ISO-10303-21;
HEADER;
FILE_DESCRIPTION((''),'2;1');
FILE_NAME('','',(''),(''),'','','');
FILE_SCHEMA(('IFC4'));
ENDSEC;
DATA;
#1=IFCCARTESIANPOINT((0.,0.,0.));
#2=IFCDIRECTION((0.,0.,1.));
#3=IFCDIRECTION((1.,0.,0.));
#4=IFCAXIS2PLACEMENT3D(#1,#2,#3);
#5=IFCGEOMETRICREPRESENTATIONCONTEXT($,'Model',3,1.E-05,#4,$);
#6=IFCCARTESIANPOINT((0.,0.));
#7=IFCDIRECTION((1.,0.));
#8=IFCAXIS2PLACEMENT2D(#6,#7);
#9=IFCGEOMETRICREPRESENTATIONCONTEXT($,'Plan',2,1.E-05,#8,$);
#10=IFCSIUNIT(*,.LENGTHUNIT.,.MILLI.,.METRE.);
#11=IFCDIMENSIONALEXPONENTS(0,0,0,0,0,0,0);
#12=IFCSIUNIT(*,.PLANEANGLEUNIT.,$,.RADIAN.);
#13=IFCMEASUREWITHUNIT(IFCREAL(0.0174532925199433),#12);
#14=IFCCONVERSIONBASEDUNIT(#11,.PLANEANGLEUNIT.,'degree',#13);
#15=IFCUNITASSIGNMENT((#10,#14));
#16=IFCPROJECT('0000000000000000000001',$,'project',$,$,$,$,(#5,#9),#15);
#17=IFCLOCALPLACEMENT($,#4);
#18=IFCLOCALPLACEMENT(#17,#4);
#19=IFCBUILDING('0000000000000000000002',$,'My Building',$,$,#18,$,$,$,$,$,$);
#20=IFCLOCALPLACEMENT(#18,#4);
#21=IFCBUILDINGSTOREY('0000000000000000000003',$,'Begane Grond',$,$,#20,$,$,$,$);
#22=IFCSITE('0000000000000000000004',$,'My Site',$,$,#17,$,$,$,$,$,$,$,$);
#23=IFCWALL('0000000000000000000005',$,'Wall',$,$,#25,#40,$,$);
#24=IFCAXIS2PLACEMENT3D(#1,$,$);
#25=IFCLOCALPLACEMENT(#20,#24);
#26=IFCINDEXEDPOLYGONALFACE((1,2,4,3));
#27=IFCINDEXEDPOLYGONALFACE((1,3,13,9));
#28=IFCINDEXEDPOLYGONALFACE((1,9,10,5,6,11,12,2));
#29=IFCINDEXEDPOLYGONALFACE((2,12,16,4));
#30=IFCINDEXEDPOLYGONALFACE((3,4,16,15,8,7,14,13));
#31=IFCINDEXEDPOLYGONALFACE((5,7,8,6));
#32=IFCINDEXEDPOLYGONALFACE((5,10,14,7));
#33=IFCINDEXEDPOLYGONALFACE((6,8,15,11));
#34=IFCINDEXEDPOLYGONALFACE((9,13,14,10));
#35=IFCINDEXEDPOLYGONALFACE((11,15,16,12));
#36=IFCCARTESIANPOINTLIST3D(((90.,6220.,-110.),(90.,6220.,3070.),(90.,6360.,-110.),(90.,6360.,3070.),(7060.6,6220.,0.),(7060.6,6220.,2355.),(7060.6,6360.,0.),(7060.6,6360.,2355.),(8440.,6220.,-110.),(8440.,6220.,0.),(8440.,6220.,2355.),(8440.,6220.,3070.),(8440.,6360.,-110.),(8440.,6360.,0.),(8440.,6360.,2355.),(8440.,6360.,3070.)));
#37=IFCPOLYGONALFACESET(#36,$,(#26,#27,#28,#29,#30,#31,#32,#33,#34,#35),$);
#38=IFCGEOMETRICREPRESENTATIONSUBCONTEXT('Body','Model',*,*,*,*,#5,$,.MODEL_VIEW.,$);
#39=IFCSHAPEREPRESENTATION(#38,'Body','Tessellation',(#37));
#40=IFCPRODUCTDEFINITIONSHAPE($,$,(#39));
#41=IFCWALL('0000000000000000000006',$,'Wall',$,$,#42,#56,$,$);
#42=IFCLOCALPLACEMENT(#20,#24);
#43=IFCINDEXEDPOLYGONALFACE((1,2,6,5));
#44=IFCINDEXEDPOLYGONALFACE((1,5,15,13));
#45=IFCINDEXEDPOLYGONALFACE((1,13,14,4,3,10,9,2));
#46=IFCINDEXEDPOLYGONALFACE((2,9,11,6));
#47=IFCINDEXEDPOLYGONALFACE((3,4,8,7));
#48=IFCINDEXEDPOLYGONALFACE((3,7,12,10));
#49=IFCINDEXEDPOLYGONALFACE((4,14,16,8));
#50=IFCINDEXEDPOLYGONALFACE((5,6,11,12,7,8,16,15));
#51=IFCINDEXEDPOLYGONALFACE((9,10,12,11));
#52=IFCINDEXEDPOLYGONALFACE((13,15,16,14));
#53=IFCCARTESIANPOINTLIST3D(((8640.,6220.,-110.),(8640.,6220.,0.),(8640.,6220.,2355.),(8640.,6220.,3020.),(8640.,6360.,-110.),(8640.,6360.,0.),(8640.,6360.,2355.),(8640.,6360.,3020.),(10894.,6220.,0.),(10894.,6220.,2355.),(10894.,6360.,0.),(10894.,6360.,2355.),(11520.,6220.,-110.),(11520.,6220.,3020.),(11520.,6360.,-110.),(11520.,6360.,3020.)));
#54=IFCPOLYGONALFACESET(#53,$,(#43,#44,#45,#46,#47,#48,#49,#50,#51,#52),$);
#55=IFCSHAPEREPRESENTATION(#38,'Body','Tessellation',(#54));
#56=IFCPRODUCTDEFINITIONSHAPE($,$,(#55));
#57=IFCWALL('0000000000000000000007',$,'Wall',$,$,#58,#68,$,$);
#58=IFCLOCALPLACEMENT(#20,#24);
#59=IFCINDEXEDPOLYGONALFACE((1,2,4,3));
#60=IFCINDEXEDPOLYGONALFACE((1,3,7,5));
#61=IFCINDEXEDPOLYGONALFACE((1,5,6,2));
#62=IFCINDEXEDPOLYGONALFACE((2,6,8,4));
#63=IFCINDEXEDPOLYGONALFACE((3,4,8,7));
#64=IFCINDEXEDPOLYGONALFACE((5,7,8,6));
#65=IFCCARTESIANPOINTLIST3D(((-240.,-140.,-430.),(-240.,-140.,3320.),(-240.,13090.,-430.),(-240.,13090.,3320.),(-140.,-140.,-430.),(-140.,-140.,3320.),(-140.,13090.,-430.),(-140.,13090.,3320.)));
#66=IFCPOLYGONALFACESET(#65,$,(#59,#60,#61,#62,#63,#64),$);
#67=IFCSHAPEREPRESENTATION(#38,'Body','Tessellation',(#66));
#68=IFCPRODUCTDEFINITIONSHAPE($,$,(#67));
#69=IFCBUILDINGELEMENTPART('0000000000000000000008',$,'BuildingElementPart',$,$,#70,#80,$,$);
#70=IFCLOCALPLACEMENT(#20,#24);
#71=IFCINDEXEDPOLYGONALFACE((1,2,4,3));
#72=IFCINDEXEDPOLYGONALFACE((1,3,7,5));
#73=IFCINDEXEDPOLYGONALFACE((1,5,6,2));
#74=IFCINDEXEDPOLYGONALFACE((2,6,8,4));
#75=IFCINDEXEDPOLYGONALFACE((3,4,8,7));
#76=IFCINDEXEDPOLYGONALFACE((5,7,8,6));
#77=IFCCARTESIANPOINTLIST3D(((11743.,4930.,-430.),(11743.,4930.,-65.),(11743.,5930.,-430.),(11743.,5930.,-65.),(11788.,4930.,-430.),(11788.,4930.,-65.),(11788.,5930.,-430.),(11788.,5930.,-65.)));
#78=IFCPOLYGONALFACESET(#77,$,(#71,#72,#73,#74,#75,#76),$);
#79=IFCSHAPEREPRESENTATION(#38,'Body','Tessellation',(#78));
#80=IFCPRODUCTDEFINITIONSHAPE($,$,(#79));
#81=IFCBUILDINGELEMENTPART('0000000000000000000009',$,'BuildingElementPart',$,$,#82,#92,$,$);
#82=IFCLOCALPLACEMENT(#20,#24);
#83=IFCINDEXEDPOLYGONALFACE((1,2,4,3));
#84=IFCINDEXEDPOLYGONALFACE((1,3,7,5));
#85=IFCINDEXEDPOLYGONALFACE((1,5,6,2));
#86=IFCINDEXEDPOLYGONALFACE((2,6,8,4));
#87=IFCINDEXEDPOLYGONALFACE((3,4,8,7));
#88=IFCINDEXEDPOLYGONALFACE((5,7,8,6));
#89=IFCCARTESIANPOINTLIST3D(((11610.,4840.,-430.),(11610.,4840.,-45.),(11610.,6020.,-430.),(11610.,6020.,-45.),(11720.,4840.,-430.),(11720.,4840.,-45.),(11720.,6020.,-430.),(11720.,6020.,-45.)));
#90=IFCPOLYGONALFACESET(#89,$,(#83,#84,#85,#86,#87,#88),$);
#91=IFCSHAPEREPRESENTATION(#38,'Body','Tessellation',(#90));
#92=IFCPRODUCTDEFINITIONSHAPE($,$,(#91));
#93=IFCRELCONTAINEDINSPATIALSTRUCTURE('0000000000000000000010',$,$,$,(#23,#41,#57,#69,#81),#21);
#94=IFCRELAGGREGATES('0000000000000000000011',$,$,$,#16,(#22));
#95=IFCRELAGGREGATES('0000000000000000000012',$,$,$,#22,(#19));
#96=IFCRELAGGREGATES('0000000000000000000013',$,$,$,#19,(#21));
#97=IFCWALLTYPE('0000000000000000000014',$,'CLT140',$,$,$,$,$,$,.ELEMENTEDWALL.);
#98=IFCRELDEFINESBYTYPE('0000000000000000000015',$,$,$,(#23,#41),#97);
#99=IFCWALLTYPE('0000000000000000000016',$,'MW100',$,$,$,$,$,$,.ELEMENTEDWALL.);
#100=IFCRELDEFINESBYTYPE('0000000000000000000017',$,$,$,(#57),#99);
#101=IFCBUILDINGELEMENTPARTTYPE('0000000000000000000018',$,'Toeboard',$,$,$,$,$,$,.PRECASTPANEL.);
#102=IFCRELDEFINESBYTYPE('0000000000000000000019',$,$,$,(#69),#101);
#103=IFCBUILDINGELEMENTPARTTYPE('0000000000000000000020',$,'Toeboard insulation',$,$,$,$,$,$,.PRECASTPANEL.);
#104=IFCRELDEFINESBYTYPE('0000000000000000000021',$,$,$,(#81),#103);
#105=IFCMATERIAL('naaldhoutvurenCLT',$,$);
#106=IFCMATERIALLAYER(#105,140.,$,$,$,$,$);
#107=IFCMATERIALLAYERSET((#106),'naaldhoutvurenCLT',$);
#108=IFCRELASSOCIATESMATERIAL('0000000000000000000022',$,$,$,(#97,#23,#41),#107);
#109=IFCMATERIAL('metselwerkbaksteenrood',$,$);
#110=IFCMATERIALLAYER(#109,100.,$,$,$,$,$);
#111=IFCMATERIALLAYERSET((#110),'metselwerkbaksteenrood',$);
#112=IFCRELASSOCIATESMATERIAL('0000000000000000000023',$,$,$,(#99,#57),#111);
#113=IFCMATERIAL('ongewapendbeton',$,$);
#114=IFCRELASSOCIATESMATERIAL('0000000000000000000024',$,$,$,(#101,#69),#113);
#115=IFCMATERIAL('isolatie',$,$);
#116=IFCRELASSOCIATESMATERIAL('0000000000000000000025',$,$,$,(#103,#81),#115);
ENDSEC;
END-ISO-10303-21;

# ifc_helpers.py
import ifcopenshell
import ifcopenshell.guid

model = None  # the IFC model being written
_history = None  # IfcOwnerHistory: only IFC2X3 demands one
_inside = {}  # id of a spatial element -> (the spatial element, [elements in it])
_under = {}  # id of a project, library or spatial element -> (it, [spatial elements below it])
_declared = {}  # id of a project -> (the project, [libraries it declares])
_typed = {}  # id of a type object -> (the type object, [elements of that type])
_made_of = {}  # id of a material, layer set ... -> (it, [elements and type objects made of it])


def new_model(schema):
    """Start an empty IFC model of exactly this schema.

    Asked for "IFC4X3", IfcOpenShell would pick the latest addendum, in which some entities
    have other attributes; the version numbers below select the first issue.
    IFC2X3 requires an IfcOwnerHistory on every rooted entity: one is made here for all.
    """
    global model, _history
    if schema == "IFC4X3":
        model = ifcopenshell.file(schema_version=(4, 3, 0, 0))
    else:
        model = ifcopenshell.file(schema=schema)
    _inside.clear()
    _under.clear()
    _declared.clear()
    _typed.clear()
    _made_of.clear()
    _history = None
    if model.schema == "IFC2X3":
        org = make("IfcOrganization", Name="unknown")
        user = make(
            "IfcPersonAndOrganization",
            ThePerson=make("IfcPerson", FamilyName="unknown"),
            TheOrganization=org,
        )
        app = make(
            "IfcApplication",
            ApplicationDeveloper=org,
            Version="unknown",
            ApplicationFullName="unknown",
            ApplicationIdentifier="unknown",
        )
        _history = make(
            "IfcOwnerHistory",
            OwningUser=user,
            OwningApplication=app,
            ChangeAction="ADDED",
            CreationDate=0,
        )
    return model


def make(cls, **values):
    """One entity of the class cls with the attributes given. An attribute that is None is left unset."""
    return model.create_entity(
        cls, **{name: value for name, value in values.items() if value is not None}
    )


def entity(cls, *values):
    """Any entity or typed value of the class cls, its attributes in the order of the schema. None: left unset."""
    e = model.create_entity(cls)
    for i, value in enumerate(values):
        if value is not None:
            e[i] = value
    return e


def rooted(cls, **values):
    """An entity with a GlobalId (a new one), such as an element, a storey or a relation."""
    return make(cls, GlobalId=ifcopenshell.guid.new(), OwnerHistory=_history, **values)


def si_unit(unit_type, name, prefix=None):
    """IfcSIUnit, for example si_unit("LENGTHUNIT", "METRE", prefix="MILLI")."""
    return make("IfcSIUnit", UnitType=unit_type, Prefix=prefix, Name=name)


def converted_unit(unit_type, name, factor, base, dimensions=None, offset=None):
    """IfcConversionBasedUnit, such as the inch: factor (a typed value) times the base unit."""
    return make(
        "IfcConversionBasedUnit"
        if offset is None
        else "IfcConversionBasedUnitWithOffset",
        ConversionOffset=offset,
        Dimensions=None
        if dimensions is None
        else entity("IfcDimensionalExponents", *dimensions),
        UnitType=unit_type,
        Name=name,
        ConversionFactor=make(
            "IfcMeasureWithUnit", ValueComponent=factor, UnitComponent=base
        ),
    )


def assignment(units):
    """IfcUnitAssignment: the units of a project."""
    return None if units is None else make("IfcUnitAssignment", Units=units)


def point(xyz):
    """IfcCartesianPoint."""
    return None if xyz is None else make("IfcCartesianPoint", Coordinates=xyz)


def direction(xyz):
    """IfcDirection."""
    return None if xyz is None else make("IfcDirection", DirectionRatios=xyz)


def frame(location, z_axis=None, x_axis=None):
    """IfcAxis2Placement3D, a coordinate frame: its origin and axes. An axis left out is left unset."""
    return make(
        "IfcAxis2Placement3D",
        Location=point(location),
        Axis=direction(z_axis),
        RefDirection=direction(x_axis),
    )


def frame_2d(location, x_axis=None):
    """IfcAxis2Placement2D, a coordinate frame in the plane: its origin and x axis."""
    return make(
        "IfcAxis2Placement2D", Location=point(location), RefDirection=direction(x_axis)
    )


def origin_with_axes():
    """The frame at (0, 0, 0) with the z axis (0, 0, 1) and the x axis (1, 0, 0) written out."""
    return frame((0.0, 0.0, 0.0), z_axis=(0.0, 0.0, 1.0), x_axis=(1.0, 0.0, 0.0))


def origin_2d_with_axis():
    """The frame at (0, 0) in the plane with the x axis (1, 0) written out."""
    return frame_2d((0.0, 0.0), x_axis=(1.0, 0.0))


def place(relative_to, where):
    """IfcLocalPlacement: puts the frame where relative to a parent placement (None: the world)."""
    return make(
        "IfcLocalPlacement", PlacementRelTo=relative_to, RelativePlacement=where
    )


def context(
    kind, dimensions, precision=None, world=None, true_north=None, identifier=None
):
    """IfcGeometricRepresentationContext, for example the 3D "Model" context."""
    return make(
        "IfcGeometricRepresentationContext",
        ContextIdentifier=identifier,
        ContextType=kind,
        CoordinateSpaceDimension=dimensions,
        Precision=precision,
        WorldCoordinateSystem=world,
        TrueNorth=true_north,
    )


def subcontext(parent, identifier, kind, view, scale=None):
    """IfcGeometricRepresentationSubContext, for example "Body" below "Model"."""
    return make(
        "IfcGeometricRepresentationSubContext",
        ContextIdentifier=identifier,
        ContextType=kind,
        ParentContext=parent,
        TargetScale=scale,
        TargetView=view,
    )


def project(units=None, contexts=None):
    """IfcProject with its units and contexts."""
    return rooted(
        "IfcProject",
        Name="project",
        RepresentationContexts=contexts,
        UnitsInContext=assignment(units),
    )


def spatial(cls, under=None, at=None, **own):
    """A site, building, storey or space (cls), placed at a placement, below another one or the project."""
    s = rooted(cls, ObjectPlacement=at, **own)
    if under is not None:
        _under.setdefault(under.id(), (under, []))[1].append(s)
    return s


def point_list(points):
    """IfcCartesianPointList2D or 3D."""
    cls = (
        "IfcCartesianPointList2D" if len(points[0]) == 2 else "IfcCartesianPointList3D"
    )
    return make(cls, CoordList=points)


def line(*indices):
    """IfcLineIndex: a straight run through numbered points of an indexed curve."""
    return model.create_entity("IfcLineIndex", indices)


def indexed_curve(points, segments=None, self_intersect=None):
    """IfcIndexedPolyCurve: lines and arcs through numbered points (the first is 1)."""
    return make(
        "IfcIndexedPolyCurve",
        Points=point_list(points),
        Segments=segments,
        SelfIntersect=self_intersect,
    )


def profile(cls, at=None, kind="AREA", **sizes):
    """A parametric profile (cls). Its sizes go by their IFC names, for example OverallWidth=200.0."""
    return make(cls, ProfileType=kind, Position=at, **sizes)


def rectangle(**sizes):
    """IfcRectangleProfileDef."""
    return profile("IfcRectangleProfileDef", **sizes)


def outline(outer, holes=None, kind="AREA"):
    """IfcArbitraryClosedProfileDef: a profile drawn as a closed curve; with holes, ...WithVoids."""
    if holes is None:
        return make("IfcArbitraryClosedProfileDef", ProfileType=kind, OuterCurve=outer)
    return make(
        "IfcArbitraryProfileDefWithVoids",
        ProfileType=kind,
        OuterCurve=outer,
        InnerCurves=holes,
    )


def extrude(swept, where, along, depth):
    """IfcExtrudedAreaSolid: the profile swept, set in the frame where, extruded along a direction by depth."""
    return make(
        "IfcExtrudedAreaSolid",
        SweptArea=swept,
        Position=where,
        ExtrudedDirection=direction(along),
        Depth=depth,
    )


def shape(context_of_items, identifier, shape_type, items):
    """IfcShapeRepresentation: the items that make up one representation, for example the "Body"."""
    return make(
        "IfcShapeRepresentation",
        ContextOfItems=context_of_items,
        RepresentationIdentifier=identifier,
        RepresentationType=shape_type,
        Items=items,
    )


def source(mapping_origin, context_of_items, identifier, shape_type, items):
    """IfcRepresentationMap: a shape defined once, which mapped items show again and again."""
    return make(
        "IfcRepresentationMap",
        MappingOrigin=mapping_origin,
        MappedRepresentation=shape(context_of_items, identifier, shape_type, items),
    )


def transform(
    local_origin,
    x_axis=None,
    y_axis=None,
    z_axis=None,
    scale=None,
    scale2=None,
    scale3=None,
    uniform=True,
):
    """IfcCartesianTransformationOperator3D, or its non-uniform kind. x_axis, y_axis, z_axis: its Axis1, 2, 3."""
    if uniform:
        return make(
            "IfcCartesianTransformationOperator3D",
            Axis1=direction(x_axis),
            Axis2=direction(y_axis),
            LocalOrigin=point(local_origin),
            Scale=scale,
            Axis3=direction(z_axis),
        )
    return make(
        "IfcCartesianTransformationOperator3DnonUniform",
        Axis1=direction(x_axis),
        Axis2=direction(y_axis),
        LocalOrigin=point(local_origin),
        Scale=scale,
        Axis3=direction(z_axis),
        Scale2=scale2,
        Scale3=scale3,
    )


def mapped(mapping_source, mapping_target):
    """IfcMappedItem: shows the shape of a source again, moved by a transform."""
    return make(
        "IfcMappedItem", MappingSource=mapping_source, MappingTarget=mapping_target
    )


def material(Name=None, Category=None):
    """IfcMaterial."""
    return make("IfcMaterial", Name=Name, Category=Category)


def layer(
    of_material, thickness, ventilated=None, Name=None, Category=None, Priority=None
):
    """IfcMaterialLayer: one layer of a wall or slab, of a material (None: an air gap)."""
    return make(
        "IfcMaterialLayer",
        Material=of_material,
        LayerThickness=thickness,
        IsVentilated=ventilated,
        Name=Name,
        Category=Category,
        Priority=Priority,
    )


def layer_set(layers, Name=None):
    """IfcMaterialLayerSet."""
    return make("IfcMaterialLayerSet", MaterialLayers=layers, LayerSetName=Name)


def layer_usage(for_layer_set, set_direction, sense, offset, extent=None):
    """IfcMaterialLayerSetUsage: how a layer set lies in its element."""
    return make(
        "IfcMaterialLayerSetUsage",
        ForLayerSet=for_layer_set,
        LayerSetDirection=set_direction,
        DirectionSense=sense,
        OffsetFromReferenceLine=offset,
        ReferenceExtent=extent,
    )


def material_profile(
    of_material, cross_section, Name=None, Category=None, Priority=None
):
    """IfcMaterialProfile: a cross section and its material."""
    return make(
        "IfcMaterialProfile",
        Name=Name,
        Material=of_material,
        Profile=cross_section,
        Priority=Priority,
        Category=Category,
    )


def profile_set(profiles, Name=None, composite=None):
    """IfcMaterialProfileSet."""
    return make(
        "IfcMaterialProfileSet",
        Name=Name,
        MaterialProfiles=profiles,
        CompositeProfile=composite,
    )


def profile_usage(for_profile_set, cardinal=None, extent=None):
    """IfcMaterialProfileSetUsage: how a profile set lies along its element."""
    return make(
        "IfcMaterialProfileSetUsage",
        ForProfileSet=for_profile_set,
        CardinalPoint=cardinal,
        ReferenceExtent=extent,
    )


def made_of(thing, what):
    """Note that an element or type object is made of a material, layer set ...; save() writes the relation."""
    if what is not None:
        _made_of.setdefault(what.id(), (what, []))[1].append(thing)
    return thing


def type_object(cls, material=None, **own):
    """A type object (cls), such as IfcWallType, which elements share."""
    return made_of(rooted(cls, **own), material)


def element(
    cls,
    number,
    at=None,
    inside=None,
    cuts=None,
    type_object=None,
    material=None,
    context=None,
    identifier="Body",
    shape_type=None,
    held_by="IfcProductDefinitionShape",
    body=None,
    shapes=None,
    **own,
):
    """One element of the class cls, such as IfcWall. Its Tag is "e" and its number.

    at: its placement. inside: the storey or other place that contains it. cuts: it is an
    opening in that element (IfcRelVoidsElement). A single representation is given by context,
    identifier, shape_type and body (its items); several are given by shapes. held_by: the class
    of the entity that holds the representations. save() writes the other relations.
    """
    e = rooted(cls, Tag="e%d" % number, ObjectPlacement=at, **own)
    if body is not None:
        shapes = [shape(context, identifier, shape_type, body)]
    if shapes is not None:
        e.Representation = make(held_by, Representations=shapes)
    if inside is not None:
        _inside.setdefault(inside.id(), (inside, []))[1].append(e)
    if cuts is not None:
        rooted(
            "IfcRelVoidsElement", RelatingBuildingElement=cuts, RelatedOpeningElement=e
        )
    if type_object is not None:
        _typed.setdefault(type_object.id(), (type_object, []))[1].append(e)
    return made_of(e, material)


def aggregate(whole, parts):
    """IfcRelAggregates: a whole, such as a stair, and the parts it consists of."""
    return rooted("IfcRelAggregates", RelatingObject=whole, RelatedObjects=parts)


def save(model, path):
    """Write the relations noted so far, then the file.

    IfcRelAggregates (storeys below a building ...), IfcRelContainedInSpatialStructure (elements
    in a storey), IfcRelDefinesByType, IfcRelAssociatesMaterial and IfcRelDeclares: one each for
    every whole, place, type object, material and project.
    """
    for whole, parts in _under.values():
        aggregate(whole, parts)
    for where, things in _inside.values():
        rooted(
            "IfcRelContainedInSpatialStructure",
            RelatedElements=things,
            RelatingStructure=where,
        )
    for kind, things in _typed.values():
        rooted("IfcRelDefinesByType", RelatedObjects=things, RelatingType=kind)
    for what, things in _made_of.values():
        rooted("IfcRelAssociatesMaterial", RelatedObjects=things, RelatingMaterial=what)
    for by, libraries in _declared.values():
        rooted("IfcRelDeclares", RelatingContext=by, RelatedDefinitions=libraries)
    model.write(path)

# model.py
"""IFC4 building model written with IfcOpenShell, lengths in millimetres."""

from ifc_helpers import new_model, entity, si_unit, converted_unit, frame, origin_with_axes, origin_2d_with_axis, place, context, subcontext, project, spatial, line, indexed_curve, rectangle, outline, extrude, source, transform, mapped, material, layer, layer_set, layer_usage, material_profile, profile_set, profile_usage, type_object, element, save


model = new_model("IFC4")

# Units and contexts
model_context = context("Model", 3, precision=1e-05, world=origin_with_axes())
plan_context = context("Plan", 2, precision=1e-05, world=origin_2d_with_axis())
body_context = subcontext(model_context, "Body", "Model", "MODEL_VIEW")
ifc_project = project(units=[si_unit("LENGTHUNIT", "METRE", prefix="MILLI"), converted_unit("PLANEANGLEUNIT", "degree", entity("IfcReal", 0.0174532925199433), si_unit("PLANEANGLEUNIT", "RADIAN"), dimensions=[0, 0, 0, 0, 0, 0, 0])], contexts=[model_context, plan_context])

# Site, building, storey
site_placement = place(None, origin_with_axes())
site = spatial("IfcSite", under=ifc_project, at=site_placement, Name="My Site")
building_placement = place(site_placement, origin_with_axes())
building = spatial("IfcBuilding", under=site, at=building_placement, Name="My Building")
storey_placement = place(building_placement, origin_with_axes())
storey = spatial("IfcBuildingStorey", under=building, at=storey_placement, Name="Begane Grond")

# Shared definitions
ifc_material_1 = material(Name="naaldhoutvurenCLT")

# Shared definitions
ifc_material_2 = material(Name="isolatie")
ifc_material_3 = material(Name="ongewapendbeton")

# Shared definitions
ifc_material_4 = material(Name="metselwerkbaksteenrood")

# Walls, openings
ifc_layer_1 = layer(ifc_material_1, 140.0)
ifc_layer_set_1 = layer_set([ifc_layer_1], Name="naaldhoutvurenCLT")
ifc_layer_usage_1 = layer_usage(ifc_layer_set_1, "AXIS2", "POSITIVE", 0.0)
wall_type_1 = type_object("IfcWallType", Name="CLT140", PredefinedType="ELEMENTEDWALL", material=ifc_layer_set_1)
wall_1_placement = place(storey_placement, frame((90.0, 6220.0, -110.0), z_axis=(0.0, 0.0, 1.0), x_axis=(1.0, -0.000001, 0.0)))
wall_1 = element("IfcWall", 1, at=wall_1_placement, inside=storey, type_object=wall_type_1, material=ifc_layer_usage_1, Name="Wall", context=body_context, shape_type="SweptSolid", body=[
    extrude(outline(indexed_curve([(0.0, 0.0), (0.0, 140.0), (8350.0, 140.0), (8350.0, 0.0), (0.0, 0.0)], self_intersect=False)), origin_with_axes(), (0.0, 0.0, 1.0), 3180.0),
])
shared_shape_1 = source(origin_with_axes(), body_context, "Body", "SweptSolid", [
    extrude(outline(indexed_curve([(0.0, 0.0), (1379.4, 0.0), (1379.4, 2355.0), (0.0, 2355.0)], segments=[line(1, 2, 3, 4, 1)])), frame((0.0, -600.0, 0.0), z_axis=(0.0, -1.0, 0.0), x_axis=(1.0, 0.0, 0.0)), (0.0, 0.0, -1.0), 1200.0),
])
opening_1_placement = place(wall_1_placement, frame((6970.6, 13.0, 110.0), z_axis=(0.0, 0.0, 1.0), x_axis=(1.0, 0.0, 0.0)))
element("IfcOpeningElement", 2, at=opening_1_placement, cuts=wall_1, PredefinedType="OPENING", context=body_context, shape_type="MappedRepresentation", body=[
    mapped(shared_shape_1, transform((0.0, 0.0, 0.0), x_axis=(1.0, 0.0, 0.0), y_axis=(0.0, 1.0, 0.0), z_axis=(0.0, 0.0, 1.0), scale=1.0)),
])
ifc_layer_usage_2 = layer_usage(ifc_layer_set_1, "AXIS2", "POSITIVE", 0.0)
wall_2_placement = place(storey_placement, frame((8640.0, 6220.0, -110.0), z_axis=(0.0, 0.0, 1.0), x_axis=(1.0, -0.000001, 0.0)))
wall_2 = element("IfcWall", 3, at=wall_2_placement, inside=storey, type_object=wall_type_1, material=ifc_layer_usage_2, Name="Wall", context=body_context, shape_type="SweptSolid", body=[
    extrude(outline(indexed_curve([(0.0, 0.0), (0.0, 140.0), (2880.0, 140.0), (2880.0, 0.0), (0.0, 0.0)], self_intersect=False)), origin_with_axes(), (0.0, 0.0, 1.0), 3130.0),
])
shared_shape_2 = source(origin_with_axes(), body_context, "Body", "SweptSolid", [
    extrude(outline(indexed_curve([(0.0, 0.0), (2254.0, 0.0), (2254.0, 2355.0), (0.0, 2355.0)], segments=[line(1, 2, 3, 4, 1)])), frame((0.0, -600.0, 0.0), z_axis=(0.0, -1.0, 0.0), x_axis=(1.0, 0.0, 0.0)), (0.0, 0.0, -1.0), 1200.0),
])
opening_2_placement = place(wall_2_placement, frame((0.0, 43.0, 110.0), z_axis=(0.0, 0.0, 1.0), x_axis=(1.0, 0.0, 0.0)))
element("IfcOpeningElement", 4, at=opening_2_placement, cuts=wall_2, PredefinedType="OPENING", context=body_context, shape_type="MappedRepresentation", body=[
    mapped(shared_shape_2, transform((0.0, 0.0, 0.0), x_axis=(1.0, 0.0, 0.0), y_axis=(0.0, 1.0, 0.0), z_axis=(0.0, 0.0, 1.0), scale=1.0)),
])

# Wall
ifc_layer_2 = layer(ifc_material_4, 100.0)
ifc_layer_set_2 = layer_set([ifc_layer_2], Name="metselwerkbaksteenrood")
ifc_layer_usage_3 = layer_usage(ifc_layer_set_2, "AXIS2", "POSITIVE", 0.0)
wall_type_2 = type_object("IfcWallType", Name="MW100", PredefinedType="ELEMENTEDWALL", material=ifc_layer_set_2)
wall_3_placement = place(storey_placement, frame((-240.0, 13090.0, -430.0), z_axis=(0.0, 0.0, 1.0), x_axis=(0.0, -1.0, 0.0)))
element("IfcWall", 5, at=wall_3_placement, inside=storey, type_object=wall_type_2, material=ifc_layer_usage_3, Name="Wall", context=body_context, shape_type="SweptSolid", body=[
    extrude(outline(indexed_curve([(0.0, 0.0), (0.0, 100.0), (13230.0, 100.0), (13230.0, 0.0), (0.0, 0.0)], self_intersect=False)), origin_with_axes(), (0.0, 0.0, 1.0), 3750.0),
])

# Building element parts
ifc_material_profile_1 = material_profile(ifc_material_3, rectangle(XDim=45.0, YDim=365.0))
ifc_profile_set_1 = profile_set([ifc_material_profile_1], Name="ongewapendbeton")
ifc_profile_usage_1 = profile_usage(ifc_profile_set_1)
building_element_part_type_1 = type_object("IfcBuildingElementPartType", Name="Toeboard", PredefinedType="PRECASTPANEL", material=ifc_profile_set_1)
building_element_part_1_placement = place(storey_placement, frame((11765.5, 4930.0, -247.5), z_axis=(0.0, 1.0, 0.0), x_axis=(-1.0, 0.0, 0.0)))
element("IfcBuildingElementPart", 6, at=building_element_part_1_placement, inside=storey, type_object=building_element_part_type_1, material=ifc_profile_usage_1, Name="BuildingElementPart", context=body_context, shape_type="SweptSolid", body=[
    extrude(rectangle(XDim=45.0, YDim=365.0), origin_with_axes(), (0.0, 0.0, 1.0), 1000.0),
])
ifc_material_profile_2 = material_profile(ifc_material_2, rectangle(XDim=110.0, YDim=385.0))
ifc_profile_set_2 = profile_set([ifc_material_profile_2], Name="isolatieEPS")
ifc_profile_usage_2 = profile_usage(ifc_profile_set_2)
building_element_part_type_2 = type_object("IfcBuildingElementPartType", Name="Toeboard insulation", PredefinedType="PRECASTPANEL", material=ifc_profile_set_2)
building_element_part_2_placement = place(storey_placement, frame((11665.0, 4840.0, -237.5), z_axis=(0.0, 1.0, 0.0), x_axis=(-1.0, 0.0, 0.0)))
element("IfcBuildingElementPart", 7, at=building_element_part_2_placement, inside=storey, type_object=building_element_part_type_2, material=ifc_profile_usage_2, Name="BuildingElementPart", context=body_context, shape_type="SweptSolid", body=[
    extrude(rectangle(XDim=110.0, YDim=385.0), origin_with_axes(), (0.0, 0.0, 1.0), 1180.0),
])

save(model, "model.ifc")
